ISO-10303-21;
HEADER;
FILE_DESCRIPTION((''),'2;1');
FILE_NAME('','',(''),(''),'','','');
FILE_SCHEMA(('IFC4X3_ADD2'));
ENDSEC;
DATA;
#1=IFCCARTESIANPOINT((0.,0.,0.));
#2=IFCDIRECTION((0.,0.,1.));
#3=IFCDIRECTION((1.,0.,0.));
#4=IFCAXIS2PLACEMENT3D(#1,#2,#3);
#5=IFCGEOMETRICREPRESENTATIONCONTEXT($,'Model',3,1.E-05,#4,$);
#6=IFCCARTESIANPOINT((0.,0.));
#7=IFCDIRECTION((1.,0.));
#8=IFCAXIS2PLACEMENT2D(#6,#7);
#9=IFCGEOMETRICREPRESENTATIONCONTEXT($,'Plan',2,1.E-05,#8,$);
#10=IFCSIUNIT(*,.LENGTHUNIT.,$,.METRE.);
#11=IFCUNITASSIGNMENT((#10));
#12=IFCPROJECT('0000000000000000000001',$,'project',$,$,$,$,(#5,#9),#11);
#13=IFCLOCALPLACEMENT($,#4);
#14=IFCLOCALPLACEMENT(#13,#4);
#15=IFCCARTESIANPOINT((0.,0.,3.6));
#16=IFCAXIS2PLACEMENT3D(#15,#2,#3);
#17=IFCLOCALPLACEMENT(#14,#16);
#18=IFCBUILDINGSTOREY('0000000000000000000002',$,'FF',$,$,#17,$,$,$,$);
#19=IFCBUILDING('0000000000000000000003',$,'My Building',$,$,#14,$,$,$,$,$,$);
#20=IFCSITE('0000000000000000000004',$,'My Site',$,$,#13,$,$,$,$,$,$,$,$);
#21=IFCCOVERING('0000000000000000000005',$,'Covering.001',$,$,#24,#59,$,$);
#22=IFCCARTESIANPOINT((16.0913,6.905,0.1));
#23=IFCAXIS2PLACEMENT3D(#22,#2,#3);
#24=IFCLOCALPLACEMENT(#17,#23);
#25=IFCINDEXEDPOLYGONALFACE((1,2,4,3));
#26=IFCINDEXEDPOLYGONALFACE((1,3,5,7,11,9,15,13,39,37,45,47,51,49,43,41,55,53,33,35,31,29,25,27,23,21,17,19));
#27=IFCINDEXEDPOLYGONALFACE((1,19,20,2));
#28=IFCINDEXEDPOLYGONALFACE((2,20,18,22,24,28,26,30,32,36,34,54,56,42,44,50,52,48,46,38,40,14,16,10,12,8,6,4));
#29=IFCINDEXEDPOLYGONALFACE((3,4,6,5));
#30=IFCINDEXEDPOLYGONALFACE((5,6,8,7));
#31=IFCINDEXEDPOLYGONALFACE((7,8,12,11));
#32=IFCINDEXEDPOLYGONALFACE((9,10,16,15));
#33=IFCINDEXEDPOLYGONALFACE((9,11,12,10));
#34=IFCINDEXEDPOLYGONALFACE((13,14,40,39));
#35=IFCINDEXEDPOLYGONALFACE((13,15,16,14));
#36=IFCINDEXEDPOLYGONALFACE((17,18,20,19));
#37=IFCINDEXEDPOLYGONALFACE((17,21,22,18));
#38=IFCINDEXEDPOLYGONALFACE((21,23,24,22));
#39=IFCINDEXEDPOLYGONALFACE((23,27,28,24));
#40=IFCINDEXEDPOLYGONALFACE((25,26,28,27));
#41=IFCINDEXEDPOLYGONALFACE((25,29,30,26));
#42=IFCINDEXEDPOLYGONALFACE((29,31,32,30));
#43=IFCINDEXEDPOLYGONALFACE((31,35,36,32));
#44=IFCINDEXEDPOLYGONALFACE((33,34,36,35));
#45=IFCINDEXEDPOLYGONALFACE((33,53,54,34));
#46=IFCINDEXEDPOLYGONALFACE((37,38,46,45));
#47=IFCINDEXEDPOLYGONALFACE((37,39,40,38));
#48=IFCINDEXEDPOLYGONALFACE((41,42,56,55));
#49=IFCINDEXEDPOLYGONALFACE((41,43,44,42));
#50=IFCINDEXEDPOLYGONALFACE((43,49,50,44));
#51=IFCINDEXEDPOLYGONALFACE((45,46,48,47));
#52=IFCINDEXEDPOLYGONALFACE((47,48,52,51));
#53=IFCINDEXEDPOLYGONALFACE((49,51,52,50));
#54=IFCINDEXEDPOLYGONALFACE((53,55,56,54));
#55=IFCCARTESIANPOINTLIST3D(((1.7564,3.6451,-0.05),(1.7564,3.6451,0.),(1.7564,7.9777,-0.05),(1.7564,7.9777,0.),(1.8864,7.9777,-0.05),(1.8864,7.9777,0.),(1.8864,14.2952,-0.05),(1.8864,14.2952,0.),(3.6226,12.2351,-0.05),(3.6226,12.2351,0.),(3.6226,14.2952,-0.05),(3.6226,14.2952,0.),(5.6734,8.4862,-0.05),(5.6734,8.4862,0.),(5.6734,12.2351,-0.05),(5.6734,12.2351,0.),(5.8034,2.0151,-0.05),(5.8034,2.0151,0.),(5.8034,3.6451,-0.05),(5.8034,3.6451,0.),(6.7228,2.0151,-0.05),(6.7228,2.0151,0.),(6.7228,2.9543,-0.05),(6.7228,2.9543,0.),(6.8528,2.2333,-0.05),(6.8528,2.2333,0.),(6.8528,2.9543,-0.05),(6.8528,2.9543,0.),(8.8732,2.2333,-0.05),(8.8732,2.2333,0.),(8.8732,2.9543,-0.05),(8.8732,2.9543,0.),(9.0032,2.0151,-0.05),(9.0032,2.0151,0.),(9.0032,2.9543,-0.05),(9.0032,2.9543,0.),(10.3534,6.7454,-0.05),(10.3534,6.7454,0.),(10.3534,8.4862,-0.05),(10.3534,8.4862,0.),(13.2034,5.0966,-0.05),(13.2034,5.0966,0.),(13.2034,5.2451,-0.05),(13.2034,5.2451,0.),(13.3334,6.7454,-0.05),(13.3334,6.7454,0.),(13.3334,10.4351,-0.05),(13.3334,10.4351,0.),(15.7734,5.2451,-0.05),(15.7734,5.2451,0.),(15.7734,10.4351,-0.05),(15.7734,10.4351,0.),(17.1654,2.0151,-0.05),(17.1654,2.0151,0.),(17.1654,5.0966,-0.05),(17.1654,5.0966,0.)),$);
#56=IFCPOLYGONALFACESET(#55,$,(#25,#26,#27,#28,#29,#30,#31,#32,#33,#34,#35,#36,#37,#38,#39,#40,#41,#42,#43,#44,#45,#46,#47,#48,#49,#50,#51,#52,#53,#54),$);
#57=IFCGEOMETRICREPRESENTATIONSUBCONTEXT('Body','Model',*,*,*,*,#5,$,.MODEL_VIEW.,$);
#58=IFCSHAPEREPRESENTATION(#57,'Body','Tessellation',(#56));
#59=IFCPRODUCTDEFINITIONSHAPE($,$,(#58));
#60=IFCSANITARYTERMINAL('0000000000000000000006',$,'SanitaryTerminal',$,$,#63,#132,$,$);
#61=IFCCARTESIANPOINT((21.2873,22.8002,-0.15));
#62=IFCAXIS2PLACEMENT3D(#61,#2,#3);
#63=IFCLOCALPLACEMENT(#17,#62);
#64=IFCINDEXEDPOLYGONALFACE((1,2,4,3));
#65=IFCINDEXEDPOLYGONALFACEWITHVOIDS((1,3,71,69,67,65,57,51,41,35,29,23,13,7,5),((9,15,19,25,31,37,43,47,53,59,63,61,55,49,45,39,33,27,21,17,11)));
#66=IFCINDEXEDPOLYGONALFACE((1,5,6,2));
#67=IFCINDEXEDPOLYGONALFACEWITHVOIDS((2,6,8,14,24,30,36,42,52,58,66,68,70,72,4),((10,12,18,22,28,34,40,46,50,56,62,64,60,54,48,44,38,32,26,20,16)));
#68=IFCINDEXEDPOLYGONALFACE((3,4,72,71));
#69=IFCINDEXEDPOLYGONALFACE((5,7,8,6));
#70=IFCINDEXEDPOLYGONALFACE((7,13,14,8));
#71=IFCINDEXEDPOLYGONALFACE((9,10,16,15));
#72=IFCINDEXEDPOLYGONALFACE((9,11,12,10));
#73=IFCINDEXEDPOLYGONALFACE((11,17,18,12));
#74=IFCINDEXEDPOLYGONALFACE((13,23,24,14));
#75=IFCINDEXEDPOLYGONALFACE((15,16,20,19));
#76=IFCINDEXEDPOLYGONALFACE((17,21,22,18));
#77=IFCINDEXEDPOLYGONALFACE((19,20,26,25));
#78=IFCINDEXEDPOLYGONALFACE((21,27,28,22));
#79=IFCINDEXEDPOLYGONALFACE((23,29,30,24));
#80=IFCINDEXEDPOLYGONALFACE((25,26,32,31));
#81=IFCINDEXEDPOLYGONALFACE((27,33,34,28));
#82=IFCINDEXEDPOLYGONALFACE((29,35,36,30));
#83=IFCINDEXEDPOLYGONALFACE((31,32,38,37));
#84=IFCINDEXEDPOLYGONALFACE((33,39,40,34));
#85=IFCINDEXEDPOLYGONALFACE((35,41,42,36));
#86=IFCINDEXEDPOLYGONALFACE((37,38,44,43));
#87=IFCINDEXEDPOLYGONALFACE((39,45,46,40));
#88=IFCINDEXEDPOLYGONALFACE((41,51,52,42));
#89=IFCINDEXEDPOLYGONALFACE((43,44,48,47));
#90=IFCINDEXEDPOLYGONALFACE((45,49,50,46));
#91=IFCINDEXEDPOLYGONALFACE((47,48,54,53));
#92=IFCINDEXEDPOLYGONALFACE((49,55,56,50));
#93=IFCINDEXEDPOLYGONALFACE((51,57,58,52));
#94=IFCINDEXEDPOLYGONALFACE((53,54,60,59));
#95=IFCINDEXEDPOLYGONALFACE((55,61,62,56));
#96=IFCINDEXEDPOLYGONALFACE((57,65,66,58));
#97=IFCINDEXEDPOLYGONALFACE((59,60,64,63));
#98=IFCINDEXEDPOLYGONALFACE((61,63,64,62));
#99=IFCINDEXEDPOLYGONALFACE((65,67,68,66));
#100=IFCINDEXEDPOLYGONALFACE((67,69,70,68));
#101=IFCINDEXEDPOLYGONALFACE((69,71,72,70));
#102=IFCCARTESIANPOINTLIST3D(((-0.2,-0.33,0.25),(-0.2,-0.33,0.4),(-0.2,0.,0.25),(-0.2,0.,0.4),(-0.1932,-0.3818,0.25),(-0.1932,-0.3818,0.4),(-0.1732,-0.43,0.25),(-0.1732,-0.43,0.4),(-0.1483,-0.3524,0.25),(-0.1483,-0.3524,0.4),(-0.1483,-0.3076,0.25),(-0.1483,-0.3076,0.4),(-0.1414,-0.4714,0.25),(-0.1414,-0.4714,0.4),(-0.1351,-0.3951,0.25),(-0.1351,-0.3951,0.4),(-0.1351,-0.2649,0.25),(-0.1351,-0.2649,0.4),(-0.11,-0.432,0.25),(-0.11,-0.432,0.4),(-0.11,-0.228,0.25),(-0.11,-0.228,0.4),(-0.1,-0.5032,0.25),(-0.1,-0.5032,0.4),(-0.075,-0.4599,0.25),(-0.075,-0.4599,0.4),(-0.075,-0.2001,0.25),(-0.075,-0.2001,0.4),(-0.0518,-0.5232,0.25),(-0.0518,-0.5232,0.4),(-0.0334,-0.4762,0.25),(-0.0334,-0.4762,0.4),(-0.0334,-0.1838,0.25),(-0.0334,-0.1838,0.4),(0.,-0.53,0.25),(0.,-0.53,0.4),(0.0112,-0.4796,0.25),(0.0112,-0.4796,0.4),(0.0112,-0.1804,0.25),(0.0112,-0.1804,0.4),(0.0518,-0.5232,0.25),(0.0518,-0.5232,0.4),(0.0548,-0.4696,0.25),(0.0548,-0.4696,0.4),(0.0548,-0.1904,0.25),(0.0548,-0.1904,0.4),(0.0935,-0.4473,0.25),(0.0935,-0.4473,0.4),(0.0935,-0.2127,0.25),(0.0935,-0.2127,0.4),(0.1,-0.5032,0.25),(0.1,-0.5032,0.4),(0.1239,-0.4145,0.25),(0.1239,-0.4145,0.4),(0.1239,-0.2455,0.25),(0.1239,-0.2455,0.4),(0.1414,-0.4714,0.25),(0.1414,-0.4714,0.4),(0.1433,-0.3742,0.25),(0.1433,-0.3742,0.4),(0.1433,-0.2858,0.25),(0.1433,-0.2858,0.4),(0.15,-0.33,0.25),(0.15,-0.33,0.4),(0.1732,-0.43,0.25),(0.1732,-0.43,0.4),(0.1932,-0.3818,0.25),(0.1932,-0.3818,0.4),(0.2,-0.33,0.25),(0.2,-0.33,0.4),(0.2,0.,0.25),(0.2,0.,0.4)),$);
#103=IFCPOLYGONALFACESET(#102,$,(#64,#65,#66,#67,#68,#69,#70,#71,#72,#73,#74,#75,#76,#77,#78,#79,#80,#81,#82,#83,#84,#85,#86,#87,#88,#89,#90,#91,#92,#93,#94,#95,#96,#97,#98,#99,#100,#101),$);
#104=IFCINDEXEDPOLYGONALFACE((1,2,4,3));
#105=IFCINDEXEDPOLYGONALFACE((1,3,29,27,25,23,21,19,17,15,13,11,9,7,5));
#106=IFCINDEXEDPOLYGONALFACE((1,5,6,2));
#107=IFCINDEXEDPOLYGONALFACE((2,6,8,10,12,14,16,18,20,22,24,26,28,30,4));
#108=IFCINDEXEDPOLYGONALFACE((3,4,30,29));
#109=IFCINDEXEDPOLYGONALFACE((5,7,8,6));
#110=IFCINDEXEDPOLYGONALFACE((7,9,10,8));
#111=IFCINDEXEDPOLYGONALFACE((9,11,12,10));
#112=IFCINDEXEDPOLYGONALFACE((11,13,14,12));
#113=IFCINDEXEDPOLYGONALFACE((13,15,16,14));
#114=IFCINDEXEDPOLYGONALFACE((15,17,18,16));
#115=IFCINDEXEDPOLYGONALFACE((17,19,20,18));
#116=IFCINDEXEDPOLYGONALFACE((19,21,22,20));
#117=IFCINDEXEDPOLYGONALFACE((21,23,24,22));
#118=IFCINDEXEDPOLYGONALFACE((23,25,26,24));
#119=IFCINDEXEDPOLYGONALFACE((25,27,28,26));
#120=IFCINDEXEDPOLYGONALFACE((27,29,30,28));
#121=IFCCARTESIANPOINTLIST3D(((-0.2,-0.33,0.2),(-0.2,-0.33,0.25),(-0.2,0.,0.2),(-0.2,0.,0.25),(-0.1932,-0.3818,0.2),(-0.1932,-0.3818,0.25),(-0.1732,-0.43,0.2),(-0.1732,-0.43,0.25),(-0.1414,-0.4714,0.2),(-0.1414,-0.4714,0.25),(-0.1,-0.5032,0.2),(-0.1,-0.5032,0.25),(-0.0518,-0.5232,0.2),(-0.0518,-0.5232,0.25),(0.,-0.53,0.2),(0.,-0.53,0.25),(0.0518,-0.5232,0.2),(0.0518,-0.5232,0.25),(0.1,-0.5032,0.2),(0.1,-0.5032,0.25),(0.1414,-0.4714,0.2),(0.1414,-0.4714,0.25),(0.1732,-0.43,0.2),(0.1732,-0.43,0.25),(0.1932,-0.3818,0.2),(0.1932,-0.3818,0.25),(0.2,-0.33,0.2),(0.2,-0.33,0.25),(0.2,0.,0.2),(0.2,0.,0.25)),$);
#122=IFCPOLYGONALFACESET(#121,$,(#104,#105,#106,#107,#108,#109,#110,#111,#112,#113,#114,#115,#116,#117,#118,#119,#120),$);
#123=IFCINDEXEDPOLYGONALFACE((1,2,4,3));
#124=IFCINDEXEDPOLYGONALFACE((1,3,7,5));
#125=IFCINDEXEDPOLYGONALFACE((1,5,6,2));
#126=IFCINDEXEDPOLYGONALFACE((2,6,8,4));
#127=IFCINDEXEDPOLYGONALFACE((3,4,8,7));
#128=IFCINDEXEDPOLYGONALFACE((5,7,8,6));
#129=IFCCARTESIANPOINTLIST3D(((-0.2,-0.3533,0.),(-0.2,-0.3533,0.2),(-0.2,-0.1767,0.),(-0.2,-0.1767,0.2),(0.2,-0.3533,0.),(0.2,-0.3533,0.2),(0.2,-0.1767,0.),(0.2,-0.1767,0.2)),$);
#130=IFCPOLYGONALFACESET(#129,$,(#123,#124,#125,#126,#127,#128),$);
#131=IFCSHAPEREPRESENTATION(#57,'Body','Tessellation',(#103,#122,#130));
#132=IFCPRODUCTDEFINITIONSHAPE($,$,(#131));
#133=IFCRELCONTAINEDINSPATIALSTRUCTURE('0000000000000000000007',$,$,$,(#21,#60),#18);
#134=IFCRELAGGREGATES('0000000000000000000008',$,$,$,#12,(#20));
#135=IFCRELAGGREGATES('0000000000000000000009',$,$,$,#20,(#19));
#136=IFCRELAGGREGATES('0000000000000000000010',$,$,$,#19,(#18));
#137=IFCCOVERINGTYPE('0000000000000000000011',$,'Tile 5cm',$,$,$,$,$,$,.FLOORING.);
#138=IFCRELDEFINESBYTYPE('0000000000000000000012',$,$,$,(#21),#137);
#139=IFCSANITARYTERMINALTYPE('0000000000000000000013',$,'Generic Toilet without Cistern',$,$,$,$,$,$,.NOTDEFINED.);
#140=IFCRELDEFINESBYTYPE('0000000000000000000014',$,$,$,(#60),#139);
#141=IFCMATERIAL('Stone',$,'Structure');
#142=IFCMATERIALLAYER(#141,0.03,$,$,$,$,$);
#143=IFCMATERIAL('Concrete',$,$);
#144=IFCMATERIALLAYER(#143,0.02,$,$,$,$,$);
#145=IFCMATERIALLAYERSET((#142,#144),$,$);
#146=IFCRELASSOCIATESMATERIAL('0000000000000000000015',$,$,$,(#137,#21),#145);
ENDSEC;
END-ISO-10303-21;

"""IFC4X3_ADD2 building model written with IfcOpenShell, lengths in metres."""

from ifc_helpers import new_model, entity, si_unit, frame, frame_2d, origin_with_axes, origin_2d_with_axis, place, context, subcontext, project, spatial, line, arc, indexed_curve, circle_curve, outline, extrude, shape, source, transform, mapped, material, layer, layer_set, layer_usage, type_object, type_shapes, element, save


model = new_model("IFC4X3_ADD2")

# Units and contexts
model_context = context("Model", 3, precision=1e-05, world=origin_with_axes())
plan_context = context("Plan", 2, precision=1e-05, world=origin_2d_with_axis())
body_context_1 = subcontext(model_context, "Body", "Model", "MODEL_VIEW")
body_context_2 = subcontext(plan_context, "Body", "Plan", "PLAN_VIEW")
ifc_project = project(units=[si_unit("LENGTHUNIT", "METRE")], contexts=[model_context, plan_context])

# Site, building, storey
site_placement = place(None, origin_with_axes())
site = spatial("IfcSite", under=ifc_project, at=site_placement, Name="My Site")
building_placement = place(site_placement, origin_with_axes())
building = spatial("IfcBuilding", under=site, at=building_placement, Name="My Building")
storey_placement = place(building_placement, frame((0.0, 0.0, 3.6), z_axis=(0.0, 0.0, 1.0), x_axis=(1.0, 0.0, 0.0)))
storey = spatial("IfcBuildingStorey", under=building, at=storey_placement, Name="FF")

# Shared definitions
ifc_material_1 = material(Name="Concrete")

# Covering
ifc_material_2 = material(Name="Stone", Category="Structure")
ifc_layer_1 = layer(ifc_material_2, 0.03)
ifc_layer_2 = layer(ifc_material_1, 0.02)
ifc_layer_set_1 = layer_set([ifc_layer_1, ifc_layer_2])
covering_type_1 = type_object("IfcCoveringType", Name="Tile 5cm", PredefinedType="FLOORING", material=ifc_layer_set_1)
ifc_layer_usage_1 = layer_usage(ifc_layer_set_1, "AXIS3", "POSITIVE", -0.05)
covering_1_placement = place(storey_placement, frame((16.0913, 6.905, 0.1), z_axis=(0.0, 0.0, 1.0), x_axis=(1.0, 0.0, 0.0)))
element("IfcCovering", 1, at=covering_1_placement, inside=storey, type_object=covering_type_1, material=ifc_layer_usage_1, Name="Covering.001", context=body_context_1, shape_type="SweptSolid", body=[
    extrude(outline(indexed_curve([(13.3334, 10.4351), (13.3334, 6.7454), (10.3534, 6.7454), (10.3534, 8.4862), (5.6734, 8.4862), (5.6734, 12.2351), (3.6226, 12.2351), (3.6226, 14.2952), (1.8864, 14.2952), (1.8864, 7.9777), (1.7564, 7.9777), (1.7564, 3.6451), (5.8034, 3.6451), (5.8034, 2.0151), (6.7228, 2.0151), (6.7228, 2.9543), (6.8528, 2.9543), (6.8528, 2.2333), (8.8732, 2.2333), (8.8732, 2.9543), (9.0032, 2.9543), (9.0032, 2.0151), (17.1654, 2.0151), (17.1654, 5.0966), (13.2034, 5.0966), (13.2034, 5.2451), (15.7734, 5.2451), (15.7734, 10.4351), (13.3334, 10.4351)])), frame((0.0, 0.0, -0.05), z_axis=(0.0, 0.0, 1.0), x_axis=(1.0, 0.0, 0.0)), (0.0, 0.0, 1.0), 0.05),
])

# Sanitary terminal
sanitary_terminal_type_1 = type_object("IfcSanitaryTerminalType", Name="Generic Toilet without Cistern", PredefinedType="NOTDEFINED")
shared_shape_1 = source(origin_with_axes(), body_context_1, "Body", "SweptSolid", [
    extrude(outline(indexed_curve([(-0.2, 0.0), (0.2, 0.0), (0.2, -0.33), (0.1414, -0.4714), (0.0, -0.53), (-0.1414, -0.4714), (-0.2, -0.33)], segments=[line(1, 2), line(2, 3), arc(3, 4, 5), arc(5, 6, 7), line(7, 1)]), holes=[circle_curve(frame_2d((0.0, -0.33)), 0.15)]), frame((0.0, 0.0, 0.25), z_axis=(0.0, 0.0, 1.0), x_axis=(1.0, 0.0, 0.0)), (0.0, 0.0, 1.0), 0.15),
    extrude(outline(indexed_curve([(-0.2, 0.0), (0.2, 0.0), (0.2, -0.33), (0.1414, -0.4714), (0.0, -0.53), (-0.1414, -0.4714), (-0.2, -0.33)], segments=[line(1, 2), line(2, 3), arc(3, 4, 5), arc(5, 6, 7), line(7, 1)])), frame((0.0, 0.0, 0.2), z_axis=(0.0, 0.0, 1.0), x_axis=(1.0, 0.0, 0.0)), (0.0, 0.0, 1.0), 0.05),
    extrude(outline(indexed_curve([(-0.2, -0.1767), (0.2, -0.1767), (0.2, -0.3533), (-0.2, -0.3533)], segments=[line(1, 2, 3, 4, 1)])), origin_with_axes(), (0.0, 0.0, 1.0), 0.2),
])
shared_shape_2 = source(origin_with_axes(), body_context_2, "Body", "GeometricSet", [
    entity("IfcGeometricCurveSet", [entity("IfcIndexedPolyCurve", entity("IfcCartesianPointList2D", [[-0.1068, -0.124], [-0.0957, -0.1129], [-0.0804, -0.1088], [0.0804, -0.1088], [0.0957, -0.1129], [0.1068, -0.124], [0.1109, -0.1393], [0.1109, -0.3476], [0.1025, -0.3926], [0.0784, -0.4308], [0.0424, -0.4563], [0.0, -0.4652], [-0.0424, -0.4563], [-0.0784, -0.4308], [-0.1025, -0.3926], [-0.1109, -0.3476], [-0.1109, -0.1393]]), [entity("IfcLineIndex", [1, 2, 3, 4, 5, 6, 7, 8, 9, 10, 11, 12, 13, 14, 15, 16, 17, 1])]), entity("IfcIndexedPolyCurve", entity("IfcCartesianPointList2D", [[-0.1962, -0.2314], [-0.1848, -0.301], [-0.1764, -0.3339], [-0.1663, -0.3651], [-0.1546, -0.3944], [-0.1414, -0.4213], [-0.1269, -0.4458], [-0.1111, -0.4675], [-0.0943, -0.4862], [-0.0765, -0.5018], [-0.0581, -0.514], [-0.039, -0.5229], [-0.0196, -0.5282], [0.0, -0.53], [0.0196, -0.5282], [0.039, -0.5229], [0.0581, -0.514], [0.0765, -0.5018], [0.0943, -0.4862], [0.1111, -0.4675], [0.1269, -0.4458], [0.1414, -0.4213], [0.1546, -0.3944], [0.1663, -0.3651], [0.1764, -0.3339], [0.1848, -0.301], [0.1962, -0.2314], [0.2, -0.159], [0.1872, 0.0], [-0.1872, 0.0], [-0.2, -0.159]]), [entity("IfcLineIndex", [1, 2, 3, 4, 5, 6, 7, 8, 9, 10, 11, 12, 13, 14, 15, 16, 17, 18, 19, 20, 21, 22, 23, 24, 25, 26, 27, 28, 29, 30, 31, 1])])]),
])
type_shapes(sanitary_terminal_type_1, [shared_shape_1, shared_shape_2])
sanitary_terminal_1_placement = place(storey_placement, frame((21.2873, 22.8002, -0.15), z_axis=(0.0, 0.0, 1.0), x_axis=(1.0, 0.0, 0.0)))
element("IfcSanitaryTerminal", 2, at=sanitary_terminal_1_placement, inside=storey, type_object=sanitary_terminal_type_1, Name="SanitaryTerminal", shapes=[
    shape(body_context_1, "Body", "MappedRepresentation", [mapped(shared_shape_1, transform((0.0, 0.0, 0.0), x_axis=(1.0, 0.0, 0.0), y_axis=(0.0, 1.0, 0.0), z_axis=(0.0, 0.0, 1.0), scale=1.0))]),
    shape(body_context_2, "Body", "MappedRepresentation", [mapped(shared_shape_2, transform((0.0, 0.0, 0.0), x_axis=(1.0, 0.0, 0.0), y_axis=(0.0, 1.0, 0.0), z_axis=(0.0, 0.0, 1.0), scale=1.0))]),
])

save(model, "model.ifc")
